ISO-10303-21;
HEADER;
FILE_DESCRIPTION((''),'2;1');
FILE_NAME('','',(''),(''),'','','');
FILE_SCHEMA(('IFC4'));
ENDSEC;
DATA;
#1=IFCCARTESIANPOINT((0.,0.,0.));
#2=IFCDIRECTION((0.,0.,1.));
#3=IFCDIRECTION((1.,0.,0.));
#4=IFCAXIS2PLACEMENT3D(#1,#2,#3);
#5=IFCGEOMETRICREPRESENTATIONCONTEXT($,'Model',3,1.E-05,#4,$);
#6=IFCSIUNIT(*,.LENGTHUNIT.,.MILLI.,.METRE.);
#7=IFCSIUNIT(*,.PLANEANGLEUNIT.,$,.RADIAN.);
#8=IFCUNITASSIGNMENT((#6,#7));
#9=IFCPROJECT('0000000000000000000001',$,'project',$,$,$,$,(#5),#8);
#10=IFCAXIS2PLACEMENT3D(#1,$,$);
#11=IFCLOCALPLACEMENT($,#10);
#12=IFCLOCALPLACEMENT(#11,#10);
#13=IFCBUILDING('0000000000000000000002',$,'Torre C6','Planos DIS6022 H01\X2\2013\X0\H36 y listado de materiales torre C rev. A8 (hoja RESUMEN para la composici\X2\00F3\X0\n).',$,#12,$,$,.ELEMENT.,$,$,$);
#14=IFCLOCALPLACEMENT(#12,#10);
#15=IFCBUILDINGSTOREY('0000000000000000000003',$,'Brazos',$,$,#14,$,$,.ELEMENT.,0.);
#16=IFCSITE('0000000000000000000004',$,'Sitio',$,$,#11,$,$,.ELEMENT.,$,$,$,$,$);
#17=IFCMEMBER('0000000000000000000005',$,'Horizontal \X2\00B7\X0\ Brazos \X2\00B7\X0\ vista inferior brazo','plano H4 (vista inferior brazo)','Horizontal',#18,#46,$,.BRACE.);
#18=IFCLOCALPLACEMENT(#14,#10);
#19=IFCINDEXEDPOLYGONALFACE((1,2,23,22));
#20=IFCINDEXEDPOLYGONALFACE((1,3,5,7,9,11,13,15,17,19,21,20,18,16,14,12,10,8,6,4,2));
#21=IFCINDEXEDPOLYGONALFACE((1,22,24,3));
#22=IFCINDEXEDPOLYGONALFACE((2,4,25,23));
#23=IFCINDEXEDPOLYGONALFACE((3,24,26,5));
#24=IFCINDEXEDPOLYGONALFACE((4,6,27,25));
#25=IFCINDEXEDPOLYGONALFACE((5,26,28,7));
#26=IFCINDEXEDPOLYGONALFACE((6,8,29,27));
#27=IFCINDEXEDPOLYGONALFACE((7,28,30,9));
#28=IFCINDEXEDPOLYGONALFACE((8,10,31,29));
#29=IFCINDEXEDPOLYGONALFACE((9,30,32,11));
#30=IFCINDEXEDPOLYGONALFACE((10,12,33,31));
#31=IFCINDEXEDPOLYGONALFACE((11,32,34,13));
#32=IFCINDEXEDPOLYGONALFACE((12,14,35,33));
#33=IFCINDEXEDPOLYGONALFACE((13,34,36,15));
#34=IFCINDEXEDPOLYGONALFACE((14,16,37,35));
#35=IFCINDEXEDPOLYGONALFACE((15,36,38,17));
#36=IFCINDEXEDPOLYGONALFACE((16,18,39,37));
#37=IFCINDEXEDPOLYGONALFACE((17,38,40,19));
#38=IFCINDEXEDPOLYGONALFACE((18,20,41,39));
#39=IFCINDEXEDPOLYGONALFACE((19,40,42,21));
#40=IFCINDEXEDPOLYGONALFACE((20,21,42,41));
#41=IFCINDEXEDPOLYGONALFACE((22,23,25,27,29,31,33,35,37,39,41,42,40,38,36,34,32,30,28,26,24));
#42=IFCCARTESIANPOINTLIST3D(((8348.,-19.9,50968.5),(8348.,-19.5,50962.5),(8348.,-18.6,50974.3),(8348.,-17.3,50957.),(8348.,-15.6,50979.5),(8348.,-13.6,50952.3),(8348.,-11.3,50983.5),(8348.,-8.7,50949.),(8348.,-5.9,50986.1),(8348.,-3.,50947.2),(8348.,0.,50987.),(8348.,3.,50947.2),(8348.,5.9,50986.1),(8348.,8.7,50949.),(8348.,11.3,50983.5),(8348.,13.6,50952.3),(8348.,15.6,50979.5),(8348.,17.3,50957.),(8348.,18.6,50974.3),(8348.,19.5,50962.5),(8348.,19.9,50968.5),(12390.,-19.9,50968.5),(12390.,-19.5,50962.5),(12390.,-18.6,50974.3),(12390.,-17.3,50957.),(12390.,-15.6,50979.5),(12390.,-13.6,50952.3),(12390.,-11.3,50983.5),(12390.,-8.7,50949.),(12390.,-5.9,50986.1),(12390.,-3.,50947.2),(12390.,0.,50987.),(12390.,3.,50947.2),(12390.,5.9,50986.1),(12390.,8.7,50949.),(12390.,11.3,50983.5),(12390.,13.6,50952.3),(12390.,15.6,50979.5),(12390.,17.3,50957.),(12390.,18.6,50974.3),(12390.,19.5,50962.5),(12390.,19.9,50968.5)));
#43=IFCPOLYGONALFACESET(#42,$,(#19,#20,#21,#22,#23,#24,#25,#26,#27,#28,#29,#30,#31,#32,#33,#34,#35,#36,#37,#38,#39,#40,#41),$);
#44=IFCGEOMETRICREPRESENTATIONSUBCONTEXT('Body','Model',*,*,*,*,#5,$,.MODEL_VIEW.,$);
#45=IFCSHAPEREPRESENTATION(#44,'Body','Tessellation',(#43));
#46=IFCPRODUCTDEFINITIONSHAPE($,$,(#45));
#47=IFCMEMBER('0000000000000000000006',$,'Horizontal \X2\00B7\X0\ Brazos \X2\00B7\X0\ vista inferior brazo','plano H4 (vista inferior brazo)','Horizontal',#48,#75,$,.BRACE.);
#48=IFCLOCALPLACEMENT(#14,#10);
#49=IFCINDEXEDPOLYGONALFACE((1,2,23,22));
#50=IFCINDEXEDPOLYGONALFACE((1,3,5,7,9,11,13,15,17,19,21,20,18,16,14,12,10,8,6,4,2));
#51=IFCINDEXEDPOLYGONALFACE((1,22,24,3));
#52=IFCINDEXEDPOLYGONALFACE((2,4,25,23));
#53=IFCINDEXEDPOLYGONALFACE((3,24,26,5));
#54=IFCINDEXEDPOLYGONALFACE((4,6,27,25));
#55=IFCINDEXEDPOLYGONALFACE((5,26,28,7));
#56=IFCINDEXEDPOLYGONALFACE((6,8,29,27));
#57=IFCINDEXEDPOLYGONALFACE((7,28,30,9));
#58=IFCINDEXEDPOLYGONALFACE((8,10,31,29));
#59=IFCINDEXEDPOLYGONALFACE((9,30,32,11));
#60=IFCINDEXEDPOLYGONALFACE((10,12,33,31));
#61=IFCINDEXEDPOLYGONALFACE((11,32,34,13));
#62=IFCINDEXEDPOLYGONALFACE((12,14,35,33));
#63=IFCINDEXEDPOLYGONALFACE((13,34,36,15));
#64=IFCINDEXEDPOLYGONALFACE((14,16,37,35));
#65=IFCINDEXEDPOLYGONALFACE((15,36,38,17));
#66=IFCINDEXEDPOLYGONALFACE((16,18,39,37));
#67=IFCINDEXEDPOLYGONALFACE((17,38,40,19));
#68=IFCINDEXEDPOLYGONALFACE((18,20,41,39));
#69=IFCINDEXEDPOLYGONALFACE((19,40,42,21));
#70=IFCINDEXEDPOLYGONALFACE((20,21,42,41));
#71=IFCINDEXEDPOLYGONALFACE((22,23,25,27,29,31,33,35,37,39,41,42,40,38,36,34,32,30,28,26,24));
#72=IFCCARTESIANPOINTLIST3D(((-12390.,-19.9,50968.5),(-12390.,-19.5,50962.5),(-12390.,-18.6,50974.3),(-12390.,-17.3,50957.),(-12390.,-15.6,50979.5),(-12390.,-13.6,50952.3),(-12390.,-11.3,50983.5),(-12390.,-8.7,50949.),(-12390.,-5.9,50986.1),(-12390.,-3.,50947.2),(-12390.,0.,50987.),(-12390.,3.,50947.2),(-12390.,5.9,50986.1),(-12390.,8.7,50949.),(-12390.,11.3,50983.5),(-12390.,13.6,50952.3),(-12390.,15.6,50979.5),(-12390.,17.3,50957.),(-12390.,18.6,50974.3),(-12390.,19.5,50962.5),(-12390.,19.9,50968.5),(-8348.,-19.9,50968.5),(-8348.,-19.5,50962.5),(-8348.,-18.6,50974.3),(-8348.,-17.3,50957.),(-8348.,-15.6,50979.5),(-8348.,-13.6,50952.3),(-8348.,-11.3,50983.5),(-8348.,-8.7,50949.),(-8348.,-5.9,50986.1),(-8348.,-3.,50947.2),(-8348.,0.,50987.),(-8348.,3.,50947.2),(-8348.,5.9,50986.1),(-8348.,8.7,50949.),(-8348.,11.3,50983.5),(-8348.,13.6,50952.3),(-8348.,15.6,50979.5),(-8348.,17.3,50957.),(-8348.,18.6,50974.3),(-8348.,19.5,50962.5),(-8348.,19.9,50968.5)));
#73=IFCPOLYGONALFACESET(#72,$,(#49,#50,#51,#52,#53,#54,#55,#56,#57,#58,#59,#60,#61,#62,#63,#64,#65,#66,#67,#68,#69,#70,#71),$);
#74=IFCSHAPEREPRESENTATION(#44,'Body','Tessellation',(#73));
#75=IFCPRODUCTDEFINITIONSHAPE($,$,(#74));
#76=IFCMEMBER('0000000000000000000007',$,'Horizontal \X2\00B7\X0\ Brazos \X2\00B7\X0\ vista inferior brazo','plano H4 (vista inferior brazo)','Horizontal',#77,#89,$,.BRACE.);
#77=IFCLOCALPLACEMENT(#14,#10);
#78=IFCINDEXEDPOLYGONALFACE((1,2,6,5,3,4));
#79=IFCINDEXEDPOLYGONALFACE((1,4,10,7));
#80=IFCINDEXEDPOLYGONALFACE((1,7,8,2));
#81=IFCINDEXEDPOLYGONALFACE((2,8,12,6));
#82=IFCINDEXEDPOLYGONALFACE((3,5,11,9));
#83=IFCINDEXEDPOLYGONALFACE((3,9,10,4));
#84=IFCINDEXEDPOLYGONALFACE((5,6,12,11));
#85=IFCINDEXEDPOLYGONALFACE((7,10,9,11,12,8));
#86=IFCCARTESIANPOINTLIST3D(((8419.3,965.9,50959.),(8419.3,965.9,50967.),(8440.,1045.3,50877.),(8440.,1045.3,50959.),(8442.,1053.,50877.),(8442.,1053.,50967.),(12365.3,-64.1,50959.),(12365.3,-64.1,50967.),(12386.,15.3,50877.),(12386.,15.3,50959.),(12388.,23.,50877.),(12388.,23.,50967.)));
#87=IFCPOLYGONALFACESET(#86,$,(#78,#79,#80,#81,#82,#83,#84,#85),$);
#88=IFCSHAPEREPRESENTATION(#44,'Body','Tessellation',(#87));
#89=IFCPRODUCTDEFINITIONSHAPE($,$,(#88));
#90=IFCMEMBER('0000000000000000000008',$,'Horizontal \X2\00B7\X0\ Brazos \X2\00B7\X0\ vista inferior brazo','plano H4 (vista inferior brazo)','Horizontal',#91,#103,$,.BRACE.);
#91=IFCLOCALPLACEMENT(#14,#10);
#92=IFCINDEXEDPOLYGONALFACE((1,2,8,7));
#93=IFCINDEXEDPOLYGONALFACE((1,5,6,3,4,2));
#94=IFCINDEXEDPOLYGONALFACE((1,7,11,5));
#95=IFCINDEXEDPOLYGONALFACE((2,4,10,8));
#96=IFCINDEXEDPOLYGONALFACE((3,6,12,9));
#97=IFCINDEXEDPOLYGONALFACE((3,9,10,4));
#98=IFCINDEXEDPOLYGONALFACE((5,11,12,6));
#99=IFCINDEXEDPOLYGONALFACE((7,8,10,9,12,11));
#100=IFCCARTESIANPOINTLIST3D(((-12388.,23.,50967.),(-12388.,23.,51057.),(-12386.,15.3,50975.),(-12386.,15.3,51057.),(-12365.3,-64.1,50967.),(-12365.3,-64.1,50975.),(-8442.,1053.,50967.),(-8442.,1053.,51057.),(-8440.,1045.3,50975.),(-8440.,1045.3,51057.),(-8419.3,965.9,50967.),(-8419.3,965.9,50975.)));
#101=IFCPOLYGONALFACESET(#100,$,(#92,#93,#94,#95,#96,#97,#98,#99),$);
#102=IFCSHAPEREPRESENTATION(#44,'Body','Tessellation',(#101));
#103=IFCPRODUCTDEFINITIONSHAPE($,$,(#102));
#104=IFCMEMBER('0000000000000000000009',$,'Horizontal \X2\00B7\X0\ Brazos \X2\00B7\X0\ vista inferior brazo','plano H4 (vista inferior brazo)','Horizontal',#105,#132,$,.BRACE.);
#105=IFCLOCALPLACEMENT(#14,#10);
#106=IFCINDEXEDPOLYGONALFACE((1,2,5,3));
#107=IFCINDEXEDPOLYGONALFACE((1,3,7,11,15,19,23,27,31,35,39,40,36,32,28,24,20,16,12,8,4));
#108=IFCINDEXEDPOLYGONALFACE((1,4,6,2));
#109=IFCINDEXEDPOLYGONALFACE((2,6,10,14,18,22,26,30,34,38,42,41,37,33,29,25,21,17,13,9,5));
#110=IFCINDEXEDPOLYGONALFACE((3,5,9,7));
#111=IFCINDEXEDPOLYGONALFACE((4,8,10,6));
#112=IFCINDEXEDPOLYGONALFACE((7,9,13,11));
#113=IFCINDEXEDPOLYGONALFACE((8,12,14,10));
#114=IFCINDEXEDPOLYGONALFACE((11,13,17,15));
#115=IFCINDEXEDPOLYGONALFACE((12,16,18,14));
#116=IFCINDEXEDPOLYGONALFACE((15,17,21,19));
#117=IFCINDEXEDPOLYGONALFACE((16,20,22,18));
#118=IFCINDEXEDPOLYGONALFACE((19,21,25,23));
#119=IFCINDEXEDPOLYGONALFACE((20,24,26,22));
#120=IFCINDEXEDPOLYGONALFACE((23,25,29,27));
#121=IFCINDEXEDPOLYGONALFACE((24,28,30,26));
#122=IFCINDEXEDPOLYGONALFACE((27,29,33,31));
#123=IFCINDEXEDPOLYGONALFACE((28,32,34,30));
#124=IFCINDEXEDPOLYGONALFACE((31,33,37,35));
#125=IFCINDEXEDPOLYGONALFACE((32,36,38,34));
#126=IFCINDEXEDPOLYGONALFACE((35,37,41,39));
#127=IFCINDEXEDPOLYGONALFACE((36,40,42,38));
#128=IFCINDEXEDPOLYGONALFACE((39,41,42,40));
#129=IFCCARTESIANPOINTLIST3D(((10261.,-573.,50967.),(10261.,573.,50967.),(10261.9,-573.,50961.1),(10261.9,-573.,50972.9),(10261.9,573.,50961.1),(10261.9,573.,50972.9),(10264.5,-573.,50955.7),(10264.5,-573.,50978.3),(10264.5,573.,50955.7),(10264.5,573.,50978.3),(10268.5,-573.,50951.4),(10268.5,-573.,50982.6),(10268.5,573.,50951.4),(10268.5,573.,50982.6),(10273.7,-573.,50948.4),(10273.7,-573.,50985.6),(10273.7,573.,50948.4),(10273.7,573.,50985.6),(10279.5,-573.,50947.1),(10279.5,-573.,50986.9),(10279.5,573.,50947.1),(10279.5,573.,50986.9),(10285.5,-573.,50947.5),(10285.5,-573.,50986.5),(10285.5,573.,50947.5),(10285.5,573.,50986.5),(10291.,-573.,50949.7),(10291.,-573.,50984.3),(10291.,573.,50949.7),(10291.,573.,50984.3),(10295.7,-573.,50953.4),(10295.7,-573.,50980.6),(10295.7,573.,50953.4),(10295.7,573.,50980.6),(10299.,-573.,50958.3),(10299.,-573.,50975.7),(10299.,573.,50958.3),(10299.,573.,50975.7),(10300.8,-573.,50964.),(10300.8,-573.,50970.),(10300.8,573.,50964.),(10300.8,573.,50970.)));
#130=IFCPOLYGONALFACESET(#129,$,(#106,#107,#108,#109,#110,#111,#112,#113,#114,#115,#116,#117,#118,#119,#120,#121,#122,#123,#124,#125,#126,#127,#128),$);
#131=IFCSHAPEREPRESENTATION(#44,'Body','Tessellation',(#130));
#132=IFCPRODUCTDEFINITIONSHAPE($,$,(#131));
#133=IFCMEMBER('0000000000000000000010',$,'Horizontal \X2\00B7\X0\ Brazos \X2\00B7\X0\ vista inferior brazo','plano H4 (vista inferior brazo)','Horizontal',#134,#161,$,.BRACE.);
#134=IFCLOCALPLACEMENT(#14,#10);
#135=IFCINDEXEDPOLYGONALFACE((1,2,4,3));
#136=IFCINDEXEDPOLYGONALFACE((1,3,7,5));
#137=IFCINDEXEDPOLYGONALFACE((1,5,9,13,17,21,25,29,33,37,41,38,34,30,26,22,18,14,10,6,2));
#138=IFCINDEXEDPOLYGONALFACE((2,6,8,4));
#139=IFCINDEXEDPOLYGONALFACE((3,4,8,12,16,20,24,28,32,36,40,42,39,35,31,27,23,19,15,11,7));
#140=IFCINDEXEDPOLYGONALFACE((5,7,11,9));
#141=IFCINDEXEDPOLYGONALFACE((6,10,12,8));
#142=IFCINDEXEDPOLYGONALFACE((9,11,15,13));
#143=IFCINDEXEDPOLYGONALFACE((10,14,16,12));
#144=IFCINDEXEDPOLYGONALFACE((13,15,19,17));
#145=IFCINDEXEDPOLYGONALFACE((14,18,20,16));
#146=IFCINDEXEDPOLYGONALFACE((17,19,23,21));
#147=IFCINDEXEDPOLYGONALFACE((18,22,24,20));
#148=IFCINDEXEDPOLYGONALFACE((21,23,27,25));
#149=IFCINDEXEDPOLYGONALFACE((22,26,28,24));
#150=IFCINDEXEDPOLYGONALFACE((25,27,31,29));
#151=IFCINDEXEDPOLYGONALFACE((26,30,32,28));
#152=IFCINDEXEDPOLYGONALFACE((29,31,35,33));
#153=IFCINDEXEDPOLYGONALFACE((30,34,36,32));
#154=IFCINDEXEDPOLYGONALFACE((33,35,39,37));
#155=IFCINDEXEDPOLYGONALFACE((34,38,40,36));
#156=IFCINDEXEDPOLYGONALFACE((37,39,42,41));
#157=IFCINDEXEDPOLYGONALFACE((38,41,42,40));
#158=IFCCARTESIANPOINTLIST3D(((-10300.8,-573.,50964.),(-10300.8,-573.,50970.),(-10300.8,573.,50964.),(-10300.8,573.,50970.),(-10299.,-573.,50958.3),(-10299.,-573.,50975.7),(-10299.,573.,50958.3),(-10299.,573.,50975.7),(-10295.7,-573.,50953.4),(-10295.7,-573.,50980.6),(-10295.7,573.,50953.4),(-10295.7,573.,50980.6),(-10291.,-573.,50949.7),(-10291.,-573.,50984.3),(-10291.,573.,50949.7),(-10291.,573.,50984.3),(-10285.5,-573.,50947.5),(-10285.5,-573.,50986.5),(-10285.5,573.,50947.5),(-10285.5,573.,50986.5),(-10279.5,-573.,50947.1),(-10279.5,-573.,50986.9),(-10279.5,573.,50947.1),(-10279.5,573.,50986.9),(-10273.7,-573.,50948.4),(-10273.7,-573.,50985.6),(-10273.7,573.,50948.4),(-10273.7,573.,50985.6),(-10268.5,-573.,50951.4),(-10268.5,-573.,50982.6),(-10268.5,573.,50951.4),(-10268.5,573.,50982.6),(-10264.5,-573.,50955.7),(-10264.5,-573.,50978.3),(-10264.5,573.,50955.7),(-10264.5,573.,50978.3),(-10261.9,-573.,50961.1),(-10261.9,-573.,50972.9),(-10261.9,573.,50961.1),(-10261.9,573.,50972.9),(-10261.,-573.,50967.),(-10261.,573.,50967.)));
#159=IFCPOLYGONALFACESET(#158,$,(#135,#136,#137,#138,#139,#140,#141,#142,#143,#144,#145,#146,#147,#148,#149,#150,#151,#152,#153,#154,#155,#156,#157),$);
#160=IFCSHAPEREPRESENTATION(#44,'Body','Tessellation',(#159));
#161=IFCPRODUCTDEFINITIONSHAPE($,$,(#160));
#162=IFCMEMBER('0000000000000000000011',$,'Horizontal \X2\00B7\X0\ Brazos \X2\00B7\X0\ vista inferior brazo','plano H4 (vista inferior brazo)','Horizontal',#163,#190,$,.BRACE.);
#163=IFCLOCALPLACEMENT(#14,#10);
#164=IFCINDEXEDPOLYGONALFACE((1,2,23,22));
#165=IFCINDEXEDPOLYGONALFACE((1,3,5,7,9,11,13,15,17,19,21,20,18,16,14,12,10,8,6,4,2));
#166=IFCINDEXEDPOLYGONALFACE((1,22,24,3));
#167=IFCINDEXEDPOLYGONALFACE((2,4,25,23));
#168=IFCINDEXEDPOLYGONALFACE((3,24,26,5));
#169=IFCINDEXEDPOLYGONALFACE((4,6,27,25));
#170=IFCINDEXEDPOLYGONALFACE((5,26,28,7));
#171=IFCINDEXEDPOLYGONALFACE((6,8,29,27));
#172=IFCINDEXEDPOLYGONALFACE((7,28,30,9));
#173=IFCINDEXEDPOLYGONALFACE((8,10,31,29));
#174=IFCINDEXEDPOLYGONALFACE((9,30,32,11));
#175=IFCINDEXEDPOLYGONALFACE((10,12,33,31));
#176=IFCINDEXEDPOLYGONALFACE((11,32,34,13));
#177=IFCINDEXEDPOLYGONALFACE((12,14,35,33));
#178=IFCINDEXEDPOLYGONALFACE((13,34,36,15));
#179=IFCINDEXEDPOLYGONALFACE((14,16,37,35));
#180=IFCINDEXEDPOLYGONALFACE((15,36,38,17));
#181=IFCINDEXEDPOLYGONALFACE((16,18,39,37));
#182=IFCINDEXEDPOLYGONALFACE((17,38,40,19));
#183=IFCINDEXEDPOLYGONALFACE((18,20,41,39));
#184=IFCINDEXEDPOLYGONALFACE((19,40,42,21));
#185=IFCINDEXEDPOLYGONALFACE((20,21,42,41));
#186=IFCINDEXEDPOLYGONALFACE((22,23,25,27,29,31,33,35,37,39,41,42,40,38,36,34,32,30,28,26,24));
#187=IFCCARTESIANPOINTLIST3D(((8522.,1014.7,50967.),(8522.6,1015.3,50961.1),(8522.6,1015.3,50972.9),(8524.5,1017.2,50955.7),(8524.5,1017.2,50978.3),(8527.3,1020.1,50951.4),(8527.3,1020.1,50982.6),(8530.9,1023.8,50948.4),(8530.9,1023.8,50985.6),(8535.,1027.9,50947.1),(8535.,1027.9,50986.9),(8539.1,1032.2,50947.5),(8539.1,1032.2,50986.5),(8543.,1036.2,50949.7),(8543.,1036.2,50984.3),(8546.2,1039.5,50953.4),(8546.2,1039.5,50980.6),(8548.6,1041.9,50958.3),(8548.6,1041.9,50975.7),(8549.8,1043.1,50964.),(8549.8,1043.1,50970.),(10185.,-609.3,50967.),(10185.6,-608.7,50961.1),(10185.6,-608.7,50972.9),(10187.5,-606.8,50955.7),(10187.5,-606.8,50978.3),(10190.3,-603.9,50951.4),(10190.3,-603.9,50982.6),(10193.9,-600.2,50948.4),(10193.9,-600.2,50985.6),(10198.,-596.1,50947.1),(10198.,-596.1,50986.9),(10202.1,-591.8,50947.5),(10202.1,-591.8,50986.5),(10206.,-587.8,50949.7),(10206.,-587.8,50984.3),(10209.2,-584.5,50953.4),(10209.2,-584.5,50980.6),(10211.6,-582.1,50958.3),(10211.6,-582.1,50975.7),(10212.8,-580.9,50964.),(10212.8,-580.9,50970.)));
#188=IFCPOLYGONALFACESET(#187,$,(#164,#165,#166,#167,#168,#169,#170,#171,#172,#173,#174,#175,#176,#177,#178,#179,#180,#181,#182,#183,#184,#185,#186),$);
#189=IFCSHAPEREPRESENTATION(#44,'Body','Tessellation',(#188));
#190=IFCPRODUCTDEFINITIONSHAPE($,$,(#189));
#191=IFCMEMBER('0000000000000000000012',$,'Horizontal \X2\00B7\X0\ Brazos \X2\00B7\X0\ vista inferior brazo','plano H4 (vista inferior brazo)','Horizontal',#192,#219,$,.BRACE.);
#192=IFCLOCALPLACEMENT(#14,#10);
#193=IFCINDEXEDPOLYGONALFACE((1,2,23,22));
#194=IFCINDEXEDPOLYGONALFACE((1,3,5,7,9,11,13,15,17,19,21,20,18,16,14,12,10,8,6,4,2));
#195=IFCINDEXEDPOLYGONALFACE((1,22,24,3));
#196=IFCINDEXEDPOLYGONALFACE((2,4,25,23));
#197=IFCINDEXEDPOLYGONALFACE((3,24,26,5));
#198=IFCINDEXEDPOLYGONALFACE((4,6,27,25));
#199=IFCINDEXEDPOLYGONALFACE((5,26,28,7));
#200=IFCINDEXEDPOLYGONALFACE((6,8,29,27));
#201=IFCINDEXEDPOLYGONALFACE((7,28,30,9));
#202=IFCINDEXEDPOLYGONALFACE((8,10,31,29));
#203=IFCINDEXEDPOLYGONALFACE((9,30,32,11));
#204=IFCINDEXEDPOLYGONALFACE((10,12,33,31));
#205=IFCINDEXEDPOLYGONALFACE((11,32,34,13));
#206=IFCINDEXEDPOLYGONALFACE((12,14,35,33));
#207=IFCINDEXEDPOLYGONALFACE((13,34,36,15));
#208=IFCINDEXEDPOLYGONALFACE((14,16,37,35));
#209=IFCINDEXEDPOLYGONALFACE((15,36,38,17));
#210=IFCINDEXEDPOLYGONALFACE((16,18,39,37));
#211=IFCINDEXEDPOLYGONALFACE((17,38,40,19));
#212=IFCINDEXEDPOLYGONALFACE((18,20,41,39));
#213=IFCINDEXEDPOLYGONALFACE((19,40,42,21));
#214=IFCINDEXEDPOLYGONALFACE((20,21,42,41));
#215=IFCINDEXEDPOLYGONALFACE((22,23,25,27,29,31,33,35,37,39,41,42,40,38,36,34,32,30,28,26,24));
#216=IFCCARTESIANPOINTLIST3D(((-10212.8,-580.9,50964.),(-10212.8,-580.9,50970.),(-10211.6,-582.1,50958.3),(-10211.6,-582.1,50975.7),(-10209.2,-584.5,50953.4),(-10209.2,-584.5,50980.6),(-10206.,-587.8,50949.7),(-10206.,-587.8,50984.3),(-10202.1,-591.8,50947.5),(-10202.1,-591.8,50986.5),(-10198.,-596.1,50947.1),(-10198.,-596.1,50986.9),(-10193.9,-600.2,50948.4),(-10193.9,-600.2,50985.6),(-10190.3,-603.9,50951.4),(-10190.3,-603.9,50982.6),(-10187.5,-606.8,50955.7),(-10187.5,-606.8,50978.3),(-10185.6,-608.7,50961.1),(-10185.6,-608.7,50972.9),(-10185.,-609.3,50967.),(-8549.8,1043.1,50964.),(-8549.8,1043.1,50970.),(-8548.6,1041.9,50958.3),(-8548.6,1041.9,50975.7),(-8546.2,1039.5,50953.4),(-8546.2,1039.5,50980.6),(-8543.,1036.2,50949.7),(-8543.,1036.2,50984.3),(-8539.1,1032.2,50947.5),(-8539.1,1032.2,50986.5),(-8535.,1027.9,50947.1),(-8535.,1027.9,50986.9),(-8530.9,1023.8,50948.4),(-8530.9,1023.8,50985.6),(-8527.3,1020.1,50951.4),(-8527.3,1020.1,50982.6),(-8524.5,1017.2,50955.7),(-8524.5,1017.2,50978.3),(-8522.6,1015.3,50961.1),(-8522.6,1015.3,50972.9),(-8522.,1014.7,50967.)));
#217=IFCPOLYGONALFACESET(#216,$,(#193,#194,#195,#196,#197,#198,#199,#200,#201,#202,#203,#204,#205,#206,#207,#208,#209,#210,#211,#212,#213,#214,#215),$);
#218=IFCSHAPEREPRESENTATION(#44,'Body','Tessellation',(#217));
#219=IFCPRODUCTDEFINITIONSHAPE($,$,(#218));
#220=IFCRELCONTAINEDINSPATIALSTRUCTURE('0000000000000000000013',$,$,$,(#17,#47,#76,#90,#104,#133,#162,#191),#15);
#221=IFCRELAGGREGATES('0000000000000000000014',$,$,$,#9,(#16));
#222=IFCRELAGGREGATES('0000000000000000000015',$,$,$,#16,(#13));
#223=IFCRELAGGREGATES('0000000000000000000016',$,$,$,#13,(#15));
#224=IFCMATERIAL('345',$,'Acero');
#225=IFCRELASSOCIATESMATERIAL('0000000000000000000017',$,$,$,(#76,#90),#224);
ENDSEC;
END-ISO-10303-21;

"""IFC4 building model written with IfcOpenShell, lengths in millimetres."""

from ifc_helpers import new_model, si_unit, frame, frame_2d, origin, origin_with_axes, place, context, subcontext, project, spatial, circle, l_section, extrude, material, element, save


model = new_model("IFC4")

# Units and contexts
model_context = context("Model", 3, precision=1e-05, world=origin_with_axes())
body_context = subcontext(model_context, "Body", "Model", "MODEL_VIEW")
ifc_project = project(units=[si_unit("LENGTHUNIT", "METRE", prefix="MILLI"), si_unit("PLANEANGLEUNIT", "RADIAN")], contexts=[model_context])

# Site, building, storey
site_placement = place(None, origin())
site = spatial("IfcSite", under=ifc_project, at=site_placement, Name="Sitio", CompositionType="ELEMENT")
building_placement = place(site_placement, origin())
building = spatial("IfcBuilding", under=site, at=building_placement, Name="Torre C6", Description="Planos DIS6022 H01–H36 y listado de materiales torre C rev. A8 (hoja RESUMEN para la composición).", CompositionType="ELEMENT")
storey_placement = place(building_placement, origin())
storey = spatial("IfcBuildingStorey", under=building, at=storey_placement, Name="Brazos", CompositionType="ELEMENT", Elevation=0.0)

# Members
ifc_material_1 = material(Name="345", Category="Acero")
for number, where, z_axis, x_axis, name in (
    (1, (8348.0, 0.0, 50967.0), (1.0, 0.0, 0.0), (0.0, 0.0, 1.0), "Horizontal · Brazos · vista inferior brazo"),
    (2, (-8348.0, 0.0, 50967.0), (-1.0, 0.0, 0.0), (0.0, 0.0, 1.0), "Horizontal · Brazos · vista inferior brazo"),
):
    element("IfcMember", number, at=place(storey_placement, frame(where, z_axis=z_axis, x_axis=x_axis)), inside=storey, Name=name, Description="plano H4 (vista inferior brazo)", ObjectType="Horizontal", PredefinedType="BRACE", context=body_context, shape_type="SweptSolid", body=[
        extrude(circle(Radius=20.0), None, (0.0, 0.0, 1.0), 4042.0),
    ])
for number, where, z_axis, x_axis, name in (
    (3, (8442.0, 1053.0, 50967.0), (0.967581, -0.252562, 0.0), (-0.252562, -0.967581, 0.0), "Horizontal · Brazos · vista inferior brazo"),
    (4, (-8442.0, 1053.0, 50967.0), (-0.967581, -0.252562, 0.0), (0.252562, -0.967581, 0.0), "Horizontal · Brazos · vista inferior brazo"),
):
    element("IfcMember", number, at=place(storey_placement, frame(where, z_axis=z_axis, x_axis=x_axis)), inside=storey, material=ifc_material_1, Name=name, Description="plano H4 (vista inferior brazo)", ObjectType="Horizontal", PredefinedType="BRACE", context=body_context, shape_type="SweptSolid", body=[
        extrude(l_section(Depth=90.0, Width=90.0, Thickness=8.0, at=frame_2d((45.0, 45.0))), None, (0.0, 0.0, 1.0), 4078.2),
    ])
for number, where, z_axis, x_axis, name in (
    (5, (10281.0, 573.0, 50967.0), (0.0, -1.0, 0.0), (-1.0, 0.0, 0.0), "Horizontal · Brazos · vista inferior brazo"),
    (6, (-10281.0, 573.0, 50967.0), (0.0, -1.0, 0.0), (1.0, 0.0, 0.0), "Horizontal · Brazos · vista inferior brazo"),
):
    element("IfcMember", number, at=place(storey_placement, frame(where, z_axis=z_axis, x_axis=x_axis)), inside=storey, Name=name, Description="plano H4 (vista inferior brazo)", ObjectType="Horizontal", PredefinedType="BRACE", context=body_context, shape_type="SweptSolid", body=[
        extrude(circle(Radius=20.0), None, (0.0, 0.0, 1.0), 1146.0),
    ])
for number, where, z_axis, x_axis, name in (
    (7, (10199.0, -595.0, 50967.0), (-0.715446, 0.698668, 0.0), (-0.698668, -0.715446, 0.0), "Horizontal · Brazos · vista inferior brazo"),
    (8, (-10199.0, -595.0, 50967.0), (0.715446, 0.698668, 0.0), (0.698668, -0.715446, 0.0), "Horizontal · Brazos · vista inferior brazo"),
):
    element("IfcMember", number, at=place(storey_placement, frame(where, z_axis=z_axis, x_axis=x_axis)), inside=storey, Name=name, Description="plano H4 (vista inferior brazo)", ObjectType="Horizontal", PredefinedType="BRACE", context=body_context, shape_type="SweptSolid", body=[
        extrude(circle(Radius=20.0), None, (0.0, 0.0, 1.0), 2324.4),
    ])

save(model, "model.ifc")
